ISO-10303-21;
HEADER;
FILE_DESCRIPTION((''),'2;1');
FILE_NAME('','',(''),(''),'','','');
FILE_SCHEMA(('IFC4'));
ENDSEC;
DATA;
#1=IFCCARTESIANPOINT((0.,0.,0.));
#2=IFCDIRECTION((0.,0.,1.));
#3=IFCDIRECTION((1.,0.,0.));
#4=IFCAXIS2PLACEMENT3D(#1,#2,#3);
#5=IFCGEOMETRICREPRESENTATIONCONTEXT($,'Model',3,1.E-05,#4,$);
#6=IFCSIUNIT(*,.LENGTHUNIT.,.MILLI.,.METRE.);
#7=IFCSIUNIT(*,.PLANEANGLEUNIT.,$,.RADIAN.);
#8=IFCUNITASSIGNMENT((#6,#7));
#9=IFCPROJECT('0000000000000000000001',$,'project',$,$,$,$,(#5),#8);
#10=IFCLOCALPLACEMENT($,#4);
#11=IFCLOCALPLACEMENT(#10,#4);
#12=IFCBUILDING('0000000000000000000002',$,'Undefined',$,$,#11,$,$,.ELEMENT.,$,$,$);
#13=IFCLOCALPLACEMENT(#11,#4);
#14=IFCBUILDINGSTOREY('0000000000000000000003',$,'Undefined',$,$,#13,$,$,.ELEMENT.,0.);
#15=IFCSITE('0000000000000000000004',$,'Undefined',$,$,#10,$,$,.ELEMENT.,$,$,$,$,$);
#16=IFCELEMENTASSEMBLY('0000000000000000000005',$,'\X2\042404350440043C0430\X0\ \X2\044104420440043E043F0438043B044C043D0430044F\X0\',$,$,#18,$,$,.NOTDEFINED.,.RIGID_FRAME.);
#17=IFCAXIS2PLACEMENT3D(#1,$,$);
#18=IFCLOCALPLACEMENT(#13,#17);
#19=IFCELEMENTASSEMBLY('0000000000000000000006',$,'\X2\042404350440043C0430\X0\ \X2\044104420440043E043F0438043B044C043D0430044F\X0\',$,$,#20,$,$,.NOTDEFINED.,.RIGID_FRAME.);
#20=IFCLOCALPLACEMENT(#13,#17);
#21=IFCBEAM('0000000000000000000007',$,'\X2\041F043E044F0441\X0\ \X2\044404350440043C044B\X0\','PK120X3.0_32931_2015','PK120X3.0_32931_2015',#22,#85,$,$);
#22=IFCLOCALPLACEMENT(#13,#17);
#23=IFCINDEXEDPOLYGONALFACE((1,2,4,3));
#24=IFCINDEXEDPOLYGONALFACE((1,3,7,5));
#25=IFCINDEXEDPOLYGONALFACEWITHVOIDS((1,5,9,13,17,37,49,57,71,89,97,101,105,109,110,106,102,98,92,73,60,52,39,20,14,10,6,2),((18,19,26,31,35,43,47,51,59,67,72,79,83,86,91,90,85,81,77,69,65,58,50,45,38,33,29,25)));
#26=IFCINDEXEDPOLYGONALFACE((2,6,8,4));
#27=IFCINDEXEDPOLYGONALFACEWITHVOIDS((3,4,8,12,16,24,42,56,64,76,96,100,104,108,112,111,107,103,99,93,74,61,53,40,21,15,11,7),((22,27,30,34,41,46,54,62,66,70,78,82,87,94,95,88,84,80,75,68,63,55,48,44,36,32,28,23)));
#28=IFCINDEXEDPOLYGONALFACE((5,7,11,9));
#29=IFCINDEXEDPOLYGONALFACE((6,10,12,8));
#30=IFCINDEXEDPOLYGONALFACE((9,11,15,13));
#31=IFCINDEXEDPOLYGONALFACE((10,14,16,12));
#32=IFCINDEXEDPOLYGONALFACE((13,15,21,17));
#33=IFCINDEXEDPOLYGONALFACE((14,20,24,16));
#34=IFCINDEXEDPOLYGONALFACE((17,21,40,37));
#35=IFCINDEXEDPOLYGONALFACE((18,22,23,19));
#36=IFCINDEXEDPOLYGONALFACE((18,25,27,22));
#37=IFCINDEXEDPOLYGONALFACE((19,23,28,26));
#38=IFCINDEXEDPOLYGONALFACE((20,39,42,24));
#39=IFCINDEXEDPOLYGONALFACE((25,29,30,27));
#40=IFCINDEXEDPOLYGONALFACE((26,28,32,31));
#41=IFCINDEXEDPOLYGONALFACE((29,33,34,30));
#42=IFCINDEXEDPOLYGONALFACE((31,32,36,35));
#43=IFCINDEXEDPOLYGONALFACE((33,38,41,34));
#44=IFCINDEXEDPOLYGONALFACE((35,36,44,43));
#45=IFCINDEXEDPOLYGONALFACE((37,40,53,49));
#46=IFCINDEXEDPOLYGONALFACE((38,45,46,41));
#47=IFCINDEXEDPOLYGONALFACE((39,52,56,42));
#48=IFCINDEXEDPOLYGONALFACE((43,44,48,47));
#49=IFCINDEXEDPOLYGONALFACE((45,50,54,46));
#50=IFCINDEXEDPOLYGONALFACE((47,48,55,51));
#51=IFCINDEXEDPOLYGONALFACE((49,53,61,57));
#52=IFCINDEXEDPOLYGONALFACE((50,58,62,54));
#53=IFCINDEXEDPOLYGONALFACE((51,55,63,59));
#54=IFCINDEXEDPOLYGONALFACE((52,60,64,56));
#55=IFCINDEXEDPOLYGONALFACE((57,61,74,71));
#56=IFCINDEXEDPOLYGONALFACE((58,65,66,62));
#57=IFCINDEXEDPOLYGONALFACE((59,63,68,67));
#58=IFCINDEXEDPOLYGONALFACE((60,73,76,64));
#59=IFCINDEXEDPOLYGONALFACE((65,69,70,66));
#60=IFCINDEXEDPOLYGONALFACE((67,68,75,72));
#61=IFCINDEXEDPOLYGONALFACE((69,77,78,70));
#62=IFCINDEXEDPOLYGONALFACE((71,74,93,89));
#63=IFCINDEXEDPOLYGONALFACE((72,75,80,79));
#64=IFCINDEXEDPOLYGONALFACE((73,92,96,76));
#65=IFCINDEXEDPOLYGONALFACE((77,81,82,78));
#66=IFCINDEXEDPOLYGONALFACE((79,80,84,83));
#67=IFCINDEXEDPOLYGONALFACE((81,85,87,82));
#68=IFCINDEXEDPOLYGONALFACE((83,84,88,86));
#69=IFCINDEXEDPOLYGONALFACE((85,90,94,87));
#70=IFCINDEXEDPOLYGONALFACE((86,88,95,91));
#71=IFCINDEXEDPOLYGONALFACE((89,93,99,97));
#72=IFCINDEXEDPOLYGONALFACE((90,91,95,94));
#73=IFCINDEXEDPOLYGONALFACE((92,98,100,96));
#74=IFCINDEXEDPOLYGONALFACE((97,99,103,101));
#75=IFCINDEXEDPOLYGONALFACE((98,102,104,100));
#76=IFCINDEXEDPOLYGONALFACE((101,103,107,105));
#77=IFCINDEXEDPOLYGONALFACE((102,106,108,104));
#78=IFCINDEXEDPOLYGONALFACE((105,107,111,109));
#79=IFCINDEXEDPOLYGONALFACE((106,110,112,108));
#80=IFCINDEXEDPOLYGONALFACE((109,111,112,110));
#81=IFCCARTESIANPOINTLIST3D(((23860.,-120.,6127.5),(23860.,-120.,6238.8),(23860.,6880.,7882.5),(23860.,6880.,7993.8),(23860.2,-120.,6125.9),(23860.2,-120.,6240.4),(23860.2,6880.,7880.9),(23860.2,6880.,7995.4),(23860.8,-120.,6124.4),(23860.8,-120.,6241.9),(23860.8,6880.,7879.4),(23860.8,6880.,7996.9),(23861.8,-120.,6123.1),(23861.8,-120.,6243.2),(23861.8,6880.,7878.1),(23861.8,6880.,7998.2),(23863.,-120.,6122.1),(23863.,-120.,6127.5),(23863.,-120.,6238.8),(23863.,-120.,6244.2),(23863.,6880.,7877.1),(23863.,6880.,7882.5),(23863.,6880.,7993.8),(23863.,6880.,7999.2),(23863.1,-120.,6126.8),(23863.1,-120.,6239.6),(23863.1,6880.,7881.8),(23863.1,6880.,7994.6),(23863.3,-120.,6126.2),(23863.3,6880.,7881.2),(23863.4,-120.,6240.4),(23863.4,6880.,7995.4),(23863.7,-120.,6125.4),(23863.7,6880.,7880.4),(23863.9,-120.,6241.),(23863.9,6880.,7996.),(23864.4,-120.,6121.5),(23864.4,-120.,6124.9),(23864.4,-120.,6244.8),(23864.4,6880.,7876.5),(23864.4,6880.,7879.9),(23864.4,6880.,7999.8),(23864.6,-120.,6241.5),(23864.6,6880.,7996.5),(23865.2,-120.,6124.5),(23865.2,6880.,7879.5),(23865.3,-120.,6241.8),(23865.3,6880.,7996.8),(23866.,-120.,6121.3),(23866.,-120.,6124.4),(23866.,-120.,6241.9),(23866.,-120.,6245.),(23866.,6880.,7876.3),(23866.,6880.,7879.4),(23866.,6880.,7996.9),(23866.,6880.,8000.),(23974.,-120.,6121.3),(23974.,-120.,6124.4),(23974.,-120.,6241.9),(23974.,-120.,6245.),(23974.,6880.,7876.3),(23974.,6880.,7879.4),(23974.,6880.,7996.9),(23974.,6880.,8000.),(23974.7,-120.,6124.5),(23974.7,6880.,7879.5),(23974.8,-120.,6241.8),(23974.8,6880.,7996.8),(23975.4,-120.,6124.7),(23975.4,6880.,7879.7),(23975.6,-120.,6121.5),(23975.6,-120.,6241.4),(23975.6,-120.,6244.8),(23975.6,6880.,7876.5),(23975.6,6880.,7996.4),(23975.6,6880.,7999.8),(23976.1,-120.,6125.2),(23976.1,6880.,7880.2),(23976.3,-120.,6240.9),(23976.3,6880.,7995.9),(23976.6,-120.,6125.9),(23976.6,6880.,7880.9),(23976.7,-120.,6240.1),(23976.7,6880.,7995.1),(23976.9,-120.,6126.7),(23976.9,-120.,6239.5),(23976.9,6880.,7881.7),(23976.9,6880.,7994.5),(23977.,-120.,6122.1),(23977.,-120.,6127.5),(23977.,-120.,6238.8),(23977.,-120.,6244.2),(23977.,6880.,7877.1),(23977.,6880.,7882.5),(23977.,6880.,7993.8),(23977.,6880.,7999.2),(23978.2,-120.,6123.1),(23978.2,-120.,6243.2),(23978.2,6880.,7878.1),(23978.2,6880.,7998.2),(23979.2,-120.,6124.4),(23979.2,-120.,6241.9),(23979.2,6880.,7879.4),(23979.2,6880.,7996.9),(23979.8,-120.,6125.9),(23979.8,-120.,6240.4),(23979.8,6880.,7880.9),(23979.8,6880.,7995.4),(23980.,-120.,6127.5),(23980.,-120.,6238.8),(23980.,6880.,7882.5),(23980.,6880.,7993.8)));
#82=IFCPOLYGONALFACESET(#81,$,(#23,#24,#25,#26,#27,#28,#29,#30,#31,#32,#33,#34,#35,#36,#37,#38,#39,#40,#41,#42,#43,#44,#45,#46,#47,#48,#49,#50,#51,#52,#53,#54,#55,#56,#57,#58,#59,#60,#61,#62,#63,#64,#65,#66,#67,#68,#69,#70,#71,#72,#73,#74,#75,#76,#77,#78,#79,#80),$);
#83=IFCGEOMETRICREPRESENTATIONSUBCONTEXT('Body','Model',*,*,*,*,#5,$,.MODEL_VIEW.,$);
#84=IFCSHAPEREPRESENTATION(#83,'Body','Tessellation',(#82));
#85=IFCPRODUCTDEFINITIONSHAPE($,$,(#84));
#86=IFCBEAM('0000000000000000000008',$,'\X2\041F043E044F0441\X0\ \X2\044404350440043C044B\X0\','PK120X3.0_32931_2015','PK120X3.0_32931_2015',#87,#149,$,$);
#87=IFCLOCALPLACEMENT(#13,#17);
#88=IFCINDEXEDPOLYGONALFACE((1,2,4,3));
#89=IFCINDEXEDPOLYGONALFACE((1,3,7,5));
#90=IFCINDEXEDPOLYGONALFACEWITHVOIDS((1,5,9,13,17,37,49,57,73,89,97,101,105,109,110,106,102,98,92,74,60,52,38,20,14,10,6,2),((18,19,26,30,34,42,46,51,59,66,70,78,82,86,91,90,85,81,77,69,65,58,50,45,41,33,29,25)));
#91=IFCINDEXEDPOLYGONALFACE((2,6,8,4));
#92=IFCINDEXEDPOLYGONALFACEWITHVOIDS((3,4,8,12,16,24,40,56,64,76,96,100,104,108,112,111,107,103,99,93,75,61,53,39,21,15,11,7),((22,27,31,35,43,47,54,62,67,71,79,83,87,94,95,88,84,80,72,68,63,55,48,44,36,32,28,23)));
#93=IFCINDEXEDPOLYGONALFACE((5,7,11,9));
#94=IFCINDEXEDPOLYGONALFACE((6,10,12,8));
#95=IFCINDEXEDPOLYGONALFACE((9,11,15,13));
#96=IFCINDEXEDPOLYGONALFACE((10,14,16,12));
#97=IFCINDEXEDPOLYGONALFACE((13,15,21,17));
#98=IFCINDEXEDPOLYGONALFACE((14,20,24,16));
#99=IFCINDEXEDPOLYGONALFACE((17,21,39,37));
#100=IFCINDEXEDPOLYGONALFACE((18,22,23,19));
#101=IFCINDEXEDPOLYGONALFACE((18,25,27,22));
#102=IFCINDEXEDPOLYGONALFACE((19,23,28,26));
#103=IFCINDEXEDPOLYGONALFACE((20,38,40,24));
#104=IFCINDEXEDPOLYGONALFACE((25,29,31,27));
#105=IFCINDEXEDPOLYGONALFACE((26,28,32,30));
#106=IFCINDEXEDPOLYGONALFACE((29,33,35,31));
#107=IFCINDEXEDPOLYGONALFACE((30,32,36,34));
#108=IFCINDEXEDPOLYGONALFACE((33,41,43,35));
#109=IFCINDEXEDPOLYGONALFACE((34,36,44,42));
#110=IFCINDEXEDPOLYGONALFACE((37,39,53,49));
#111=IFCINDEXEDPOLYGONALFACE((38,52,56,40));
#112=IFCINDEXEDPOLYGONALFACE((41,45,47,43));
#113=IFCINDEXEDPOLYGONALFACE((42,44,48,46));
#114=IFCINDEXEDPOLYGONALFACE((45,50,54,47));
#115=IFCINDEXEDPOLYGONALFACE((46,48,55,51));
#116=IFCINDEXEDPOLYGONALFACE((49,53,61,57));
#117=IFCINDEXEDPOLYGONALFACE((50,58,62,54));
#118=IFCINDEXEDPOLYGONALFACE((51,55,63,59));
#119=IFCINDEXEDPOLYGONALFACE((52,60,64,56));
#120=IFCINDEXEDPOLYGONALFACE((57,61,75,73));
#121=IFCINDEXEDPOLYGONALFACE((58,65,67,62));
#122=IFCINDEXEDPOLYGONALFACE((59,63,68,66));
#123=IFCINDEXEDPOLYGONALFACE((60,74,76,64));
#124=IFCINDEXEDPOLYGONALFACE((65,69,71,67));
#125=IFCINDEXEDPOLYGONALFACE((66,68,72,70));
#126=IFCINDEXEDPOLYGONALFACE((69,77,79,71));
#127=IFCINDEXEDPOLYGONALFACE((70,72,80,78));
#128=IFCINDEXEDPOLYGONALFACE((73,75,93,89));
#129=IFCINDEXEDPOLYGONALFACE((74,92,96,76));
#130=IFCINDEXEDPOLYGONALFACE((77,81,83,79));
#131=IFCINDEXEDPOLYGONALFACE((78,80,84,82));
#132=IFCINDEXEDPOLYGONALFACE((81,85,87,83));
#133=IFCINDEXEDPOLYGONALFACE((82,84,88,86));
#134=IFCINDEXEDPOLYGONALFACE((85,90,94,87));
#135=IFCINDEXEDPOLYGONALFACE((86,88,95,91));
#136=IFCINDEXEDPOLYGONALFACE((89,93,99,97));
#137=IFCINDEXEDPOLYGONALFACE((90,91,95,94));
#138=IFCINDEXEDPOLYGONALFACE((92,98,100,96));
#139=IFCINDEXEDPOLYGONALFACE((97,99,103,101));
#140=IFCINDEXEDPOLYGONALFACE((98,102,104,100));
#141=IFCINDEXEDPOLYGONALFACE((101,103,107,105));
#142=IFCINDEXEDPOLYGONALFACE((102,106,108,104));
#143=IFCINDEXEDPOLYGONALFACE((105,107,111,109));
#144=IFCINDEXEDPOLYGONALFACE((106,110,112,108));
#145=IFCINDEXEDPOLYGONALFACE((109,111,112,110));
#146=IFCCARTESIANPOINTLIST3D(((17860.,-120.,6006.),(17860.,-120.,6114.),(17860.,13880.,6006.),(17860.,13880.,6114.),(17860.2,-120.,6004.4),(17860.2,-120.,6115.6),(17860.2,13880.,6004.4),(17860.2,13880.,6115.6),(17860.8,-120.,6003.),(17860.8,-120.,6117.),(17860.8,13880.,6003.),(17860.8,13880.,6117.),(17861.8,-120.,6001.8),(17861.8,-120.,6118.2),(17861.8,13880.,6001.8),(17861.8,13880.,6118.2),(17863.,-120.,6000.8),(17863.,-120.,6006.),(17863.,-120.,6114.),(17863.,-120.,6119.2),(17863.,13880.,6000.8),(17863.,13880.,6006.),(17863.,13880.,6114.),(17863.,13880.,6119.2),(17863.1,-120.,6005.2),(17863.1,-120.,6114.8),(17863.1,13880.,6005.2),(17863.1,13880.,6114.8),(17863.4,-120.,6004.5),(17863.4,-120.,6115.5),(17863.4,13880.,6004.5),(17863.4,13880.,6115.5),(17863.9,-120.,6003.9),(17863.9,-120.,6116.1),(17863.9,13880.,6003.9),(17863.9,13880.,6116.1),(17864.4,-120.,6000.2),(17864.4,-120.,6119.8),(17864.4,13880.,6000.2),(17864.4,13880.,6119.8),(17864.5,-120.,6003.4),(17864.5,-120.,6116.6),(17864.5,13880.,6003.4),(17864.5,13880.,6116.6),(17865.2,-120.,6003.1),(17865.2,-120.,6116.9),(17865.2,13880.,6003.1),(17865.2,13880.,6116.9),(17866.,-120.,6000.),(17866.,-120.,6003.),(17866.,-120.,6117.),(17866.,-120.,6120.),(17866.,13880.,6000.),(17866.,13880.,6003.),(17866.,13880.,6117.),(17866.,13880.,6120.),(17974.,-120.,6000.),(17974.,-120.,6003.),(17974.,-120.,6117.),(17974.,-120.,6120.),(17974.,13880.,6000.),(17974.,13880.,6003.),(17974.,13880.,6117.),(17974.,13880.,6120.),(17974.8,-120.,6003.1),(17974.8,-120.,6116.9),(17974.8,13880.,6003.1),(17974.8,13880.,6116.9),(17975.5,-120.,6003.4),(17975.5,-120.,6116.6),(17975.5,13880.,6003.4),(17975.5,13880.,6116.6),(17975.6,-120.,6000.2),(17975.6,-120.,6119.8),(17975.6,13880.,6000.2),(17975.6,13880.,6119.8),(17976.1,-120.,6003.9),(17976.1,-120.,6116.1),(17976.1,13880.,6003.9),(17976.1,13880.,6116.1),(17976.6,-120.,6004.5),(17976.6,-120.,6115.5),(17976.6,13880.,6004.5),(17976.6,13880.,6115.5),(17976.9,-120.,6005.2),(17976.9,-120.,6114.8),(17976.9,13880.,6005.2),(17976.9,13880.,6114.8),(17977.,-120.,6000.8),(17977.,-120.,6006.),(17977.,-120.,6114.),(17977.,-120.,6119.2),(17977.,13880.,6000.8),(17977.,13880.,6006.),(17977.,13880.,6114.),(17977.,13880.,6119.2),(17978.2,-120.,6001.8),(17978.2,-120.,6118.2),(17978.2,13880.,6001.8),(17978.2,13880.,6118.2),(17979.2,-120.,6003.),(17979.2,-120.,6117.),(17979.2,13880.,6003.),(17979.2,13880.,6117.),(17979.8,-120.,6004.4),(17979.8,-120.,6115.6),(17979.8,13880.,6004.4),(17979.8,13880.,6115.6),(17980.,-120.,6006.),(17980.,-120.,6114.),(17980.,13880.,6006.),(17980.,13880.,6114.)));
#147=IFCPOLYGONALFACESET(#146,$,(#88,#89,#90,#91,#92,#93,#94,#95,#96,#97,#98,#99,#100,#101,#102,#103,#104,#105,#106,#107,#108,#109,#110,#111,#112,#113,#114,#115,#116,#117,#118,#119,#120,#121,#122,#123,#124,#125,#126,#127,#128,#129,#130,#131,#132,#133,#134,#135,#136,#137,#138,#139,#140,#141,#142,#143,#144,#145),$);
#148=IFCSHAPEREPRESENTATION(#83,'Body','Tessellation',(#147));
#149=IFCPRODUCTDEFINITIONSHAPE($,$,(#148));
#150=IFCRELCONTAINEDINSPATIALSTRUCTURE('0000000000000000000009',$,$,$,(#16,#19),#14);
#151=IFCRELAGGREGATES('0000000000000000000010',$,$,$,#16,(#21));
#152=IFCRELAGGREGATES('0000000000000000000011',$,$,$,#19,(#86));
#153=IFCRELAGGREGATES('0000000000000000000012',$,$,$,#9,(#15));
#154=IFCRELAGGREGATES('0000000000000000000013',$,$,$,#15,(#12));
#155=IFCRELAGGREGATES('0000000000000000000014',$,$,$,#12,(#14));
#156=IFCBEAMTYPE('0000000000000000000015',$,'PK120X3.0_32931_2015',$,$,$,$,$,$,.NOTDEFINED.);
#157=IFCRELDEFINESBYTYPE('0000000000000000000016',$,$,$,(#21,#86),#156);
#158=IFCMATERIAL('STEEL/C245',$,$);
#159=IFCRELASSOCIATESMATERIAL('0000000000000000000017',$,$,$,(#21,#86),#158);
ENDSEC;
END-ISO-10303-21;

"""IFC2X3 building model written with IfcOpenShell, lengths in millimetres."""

from ifc_helpers import new_model, si_unit, frame, origin_with_axes, origin_2d_with_axis, place, context, subcontext, project, spatial, hollow_rectangle, extrude, clip, halfspace, material, type_object, element, aggregate, save


model = new_model("IFC2X3")

# Units and contexts
model_context = context("Model", 3, precision=1e-05, world=origin_with_axes())
body_context = subcontext(model_context, "Body", "Model", "MODEL_VIEW")
ifc_project = project(units=[si_unit("LENGTHUNIT", "METRE", prefix="MILLI"), si_unit("PLANEANGLEUNIT", "RADIAN")], contexts=[model_context])

# Site, building, storey
site_placement = place(None, origin_with_axes())
site = spatial("IfcSite", under=ifc_project, at=site_placement, Name="Undefined", CompositionType="ELEMENT")
building_placement = place(site_placement, origin_with_axes())
building = spatial("IfcBuilding", under=site, at=building_placement, Name="Undefined", CompositionType="ELEMENT")
storey_placement = place(building_placement, origin_with_axes())
storey = spatial("IfcBuildingStorey", under=building, at=storey_placement, Name="Undefined", CompositionType="ELEMENT", Elevation=0.0)

# Shared definitions
ifc_material = material(Name="STEEL/C245")

# Element assemblies
assembly_1_placement = place(storey_placement, origin_with_axes())
assembly_1 = element("IfcElementAssembly", 1, at=assembly_1_placement, inside=storey, Name="Ферма стропильная", AssemblyPlace="NOTDEFINED", PredefinedType="RIGID_FRAME")
assembly_2_placement = place(storey_placement, origin_with_axes())
assembly_2 = element("IfcElementAssembly", 2, at=assembly_2_placement, inside=storey, Name="Ферма стропильная", AssemblyPlace="NOTDEFINED", PredefinedType="RIGID_FRAME")

# Beams
beam_type_1 = type_object("IfcBeamType", Name="PK120X3.0_32931_2015", PredefinedType="NOTDEFINED")
beam_1_placement = place(assembly_1_placement, frame((23920.0, -105.4, 6186.8), z_axis=(0.0, -0.243188, 0.969979), x_axis=(0.0, 0.969979, 0.243188)))
beam_1 = element("IfcBeam", 3, at=beam_1_placement, type_object=beam_type_1, material=ifc_material, Name="Пояс фермы", Description="PK120X3.0_32931_2015", ObjectType="PK120X3.0_32931_2015", context=body_context, shape_type="Clipping", body=[
    clip(clip(extrude(hollow_rectangle(XDim=120.0, YDim=120.0, WallThickness=3.0, InnerFilletRadius=3.0, OuterFilletRadius=6.0, at=origin_2d_with_axis()), frame((7232.0, 0.0, 0.0), z_axis=(-1.0, 0.0, 0.0), x_axis=(0.0, -1.0, 0.0)), (0.0, 0.0, 1.0), 7277.4), halfspace(frame((7216.6, 0.0, 60.0), z_axis=(0.969979, 0.0, -0.243188), x_axis=(0.0, -1.0, 0.0)), False)), halfspace(frame((0.0, 0.0, 60.0), z_axis=(0.969979, 0.0, -0.243188), x_axis=(0.0, -1.0, 0.0)), True)),
])
aggregate(assembly_1, [beam_1])
beam_2_placement = place(assembly_2_placement, frame((17920.0, -120.0, 6060.0), z_axis=(0.0, 0.0, 1.0), x_axis=(0.0, 1.0, 0.0)))
beam_2 = element("IfcBeam", 4, at=beam_2_placement, type_object=beam_type_1, material=ifc_material, Name="Пояс фермы", Description="PK120X3.0_32931_2015", ObjectType="PK120X3.0_32931_2015", context=body_context, shape_type="SweptSolid", body=[
    extrude(hollow_rectangle(XDim=120.0, YDim=120.0, WallThickness=3.0, InnerFilletRadius=3.0, OuterFilletRadius=6.0, at=origin_2d_with_axis()), frame((14000.0, 0.0, 0.0), z_axis=(-1.0, 0.0, 0.0), x_axis=(0.0, -1.0, 0.0)), (0.0, 0.0, 1.0), 14000.0),
])
aggregate(assembly_2, [beam_2])

save(model, "model.ifc")
